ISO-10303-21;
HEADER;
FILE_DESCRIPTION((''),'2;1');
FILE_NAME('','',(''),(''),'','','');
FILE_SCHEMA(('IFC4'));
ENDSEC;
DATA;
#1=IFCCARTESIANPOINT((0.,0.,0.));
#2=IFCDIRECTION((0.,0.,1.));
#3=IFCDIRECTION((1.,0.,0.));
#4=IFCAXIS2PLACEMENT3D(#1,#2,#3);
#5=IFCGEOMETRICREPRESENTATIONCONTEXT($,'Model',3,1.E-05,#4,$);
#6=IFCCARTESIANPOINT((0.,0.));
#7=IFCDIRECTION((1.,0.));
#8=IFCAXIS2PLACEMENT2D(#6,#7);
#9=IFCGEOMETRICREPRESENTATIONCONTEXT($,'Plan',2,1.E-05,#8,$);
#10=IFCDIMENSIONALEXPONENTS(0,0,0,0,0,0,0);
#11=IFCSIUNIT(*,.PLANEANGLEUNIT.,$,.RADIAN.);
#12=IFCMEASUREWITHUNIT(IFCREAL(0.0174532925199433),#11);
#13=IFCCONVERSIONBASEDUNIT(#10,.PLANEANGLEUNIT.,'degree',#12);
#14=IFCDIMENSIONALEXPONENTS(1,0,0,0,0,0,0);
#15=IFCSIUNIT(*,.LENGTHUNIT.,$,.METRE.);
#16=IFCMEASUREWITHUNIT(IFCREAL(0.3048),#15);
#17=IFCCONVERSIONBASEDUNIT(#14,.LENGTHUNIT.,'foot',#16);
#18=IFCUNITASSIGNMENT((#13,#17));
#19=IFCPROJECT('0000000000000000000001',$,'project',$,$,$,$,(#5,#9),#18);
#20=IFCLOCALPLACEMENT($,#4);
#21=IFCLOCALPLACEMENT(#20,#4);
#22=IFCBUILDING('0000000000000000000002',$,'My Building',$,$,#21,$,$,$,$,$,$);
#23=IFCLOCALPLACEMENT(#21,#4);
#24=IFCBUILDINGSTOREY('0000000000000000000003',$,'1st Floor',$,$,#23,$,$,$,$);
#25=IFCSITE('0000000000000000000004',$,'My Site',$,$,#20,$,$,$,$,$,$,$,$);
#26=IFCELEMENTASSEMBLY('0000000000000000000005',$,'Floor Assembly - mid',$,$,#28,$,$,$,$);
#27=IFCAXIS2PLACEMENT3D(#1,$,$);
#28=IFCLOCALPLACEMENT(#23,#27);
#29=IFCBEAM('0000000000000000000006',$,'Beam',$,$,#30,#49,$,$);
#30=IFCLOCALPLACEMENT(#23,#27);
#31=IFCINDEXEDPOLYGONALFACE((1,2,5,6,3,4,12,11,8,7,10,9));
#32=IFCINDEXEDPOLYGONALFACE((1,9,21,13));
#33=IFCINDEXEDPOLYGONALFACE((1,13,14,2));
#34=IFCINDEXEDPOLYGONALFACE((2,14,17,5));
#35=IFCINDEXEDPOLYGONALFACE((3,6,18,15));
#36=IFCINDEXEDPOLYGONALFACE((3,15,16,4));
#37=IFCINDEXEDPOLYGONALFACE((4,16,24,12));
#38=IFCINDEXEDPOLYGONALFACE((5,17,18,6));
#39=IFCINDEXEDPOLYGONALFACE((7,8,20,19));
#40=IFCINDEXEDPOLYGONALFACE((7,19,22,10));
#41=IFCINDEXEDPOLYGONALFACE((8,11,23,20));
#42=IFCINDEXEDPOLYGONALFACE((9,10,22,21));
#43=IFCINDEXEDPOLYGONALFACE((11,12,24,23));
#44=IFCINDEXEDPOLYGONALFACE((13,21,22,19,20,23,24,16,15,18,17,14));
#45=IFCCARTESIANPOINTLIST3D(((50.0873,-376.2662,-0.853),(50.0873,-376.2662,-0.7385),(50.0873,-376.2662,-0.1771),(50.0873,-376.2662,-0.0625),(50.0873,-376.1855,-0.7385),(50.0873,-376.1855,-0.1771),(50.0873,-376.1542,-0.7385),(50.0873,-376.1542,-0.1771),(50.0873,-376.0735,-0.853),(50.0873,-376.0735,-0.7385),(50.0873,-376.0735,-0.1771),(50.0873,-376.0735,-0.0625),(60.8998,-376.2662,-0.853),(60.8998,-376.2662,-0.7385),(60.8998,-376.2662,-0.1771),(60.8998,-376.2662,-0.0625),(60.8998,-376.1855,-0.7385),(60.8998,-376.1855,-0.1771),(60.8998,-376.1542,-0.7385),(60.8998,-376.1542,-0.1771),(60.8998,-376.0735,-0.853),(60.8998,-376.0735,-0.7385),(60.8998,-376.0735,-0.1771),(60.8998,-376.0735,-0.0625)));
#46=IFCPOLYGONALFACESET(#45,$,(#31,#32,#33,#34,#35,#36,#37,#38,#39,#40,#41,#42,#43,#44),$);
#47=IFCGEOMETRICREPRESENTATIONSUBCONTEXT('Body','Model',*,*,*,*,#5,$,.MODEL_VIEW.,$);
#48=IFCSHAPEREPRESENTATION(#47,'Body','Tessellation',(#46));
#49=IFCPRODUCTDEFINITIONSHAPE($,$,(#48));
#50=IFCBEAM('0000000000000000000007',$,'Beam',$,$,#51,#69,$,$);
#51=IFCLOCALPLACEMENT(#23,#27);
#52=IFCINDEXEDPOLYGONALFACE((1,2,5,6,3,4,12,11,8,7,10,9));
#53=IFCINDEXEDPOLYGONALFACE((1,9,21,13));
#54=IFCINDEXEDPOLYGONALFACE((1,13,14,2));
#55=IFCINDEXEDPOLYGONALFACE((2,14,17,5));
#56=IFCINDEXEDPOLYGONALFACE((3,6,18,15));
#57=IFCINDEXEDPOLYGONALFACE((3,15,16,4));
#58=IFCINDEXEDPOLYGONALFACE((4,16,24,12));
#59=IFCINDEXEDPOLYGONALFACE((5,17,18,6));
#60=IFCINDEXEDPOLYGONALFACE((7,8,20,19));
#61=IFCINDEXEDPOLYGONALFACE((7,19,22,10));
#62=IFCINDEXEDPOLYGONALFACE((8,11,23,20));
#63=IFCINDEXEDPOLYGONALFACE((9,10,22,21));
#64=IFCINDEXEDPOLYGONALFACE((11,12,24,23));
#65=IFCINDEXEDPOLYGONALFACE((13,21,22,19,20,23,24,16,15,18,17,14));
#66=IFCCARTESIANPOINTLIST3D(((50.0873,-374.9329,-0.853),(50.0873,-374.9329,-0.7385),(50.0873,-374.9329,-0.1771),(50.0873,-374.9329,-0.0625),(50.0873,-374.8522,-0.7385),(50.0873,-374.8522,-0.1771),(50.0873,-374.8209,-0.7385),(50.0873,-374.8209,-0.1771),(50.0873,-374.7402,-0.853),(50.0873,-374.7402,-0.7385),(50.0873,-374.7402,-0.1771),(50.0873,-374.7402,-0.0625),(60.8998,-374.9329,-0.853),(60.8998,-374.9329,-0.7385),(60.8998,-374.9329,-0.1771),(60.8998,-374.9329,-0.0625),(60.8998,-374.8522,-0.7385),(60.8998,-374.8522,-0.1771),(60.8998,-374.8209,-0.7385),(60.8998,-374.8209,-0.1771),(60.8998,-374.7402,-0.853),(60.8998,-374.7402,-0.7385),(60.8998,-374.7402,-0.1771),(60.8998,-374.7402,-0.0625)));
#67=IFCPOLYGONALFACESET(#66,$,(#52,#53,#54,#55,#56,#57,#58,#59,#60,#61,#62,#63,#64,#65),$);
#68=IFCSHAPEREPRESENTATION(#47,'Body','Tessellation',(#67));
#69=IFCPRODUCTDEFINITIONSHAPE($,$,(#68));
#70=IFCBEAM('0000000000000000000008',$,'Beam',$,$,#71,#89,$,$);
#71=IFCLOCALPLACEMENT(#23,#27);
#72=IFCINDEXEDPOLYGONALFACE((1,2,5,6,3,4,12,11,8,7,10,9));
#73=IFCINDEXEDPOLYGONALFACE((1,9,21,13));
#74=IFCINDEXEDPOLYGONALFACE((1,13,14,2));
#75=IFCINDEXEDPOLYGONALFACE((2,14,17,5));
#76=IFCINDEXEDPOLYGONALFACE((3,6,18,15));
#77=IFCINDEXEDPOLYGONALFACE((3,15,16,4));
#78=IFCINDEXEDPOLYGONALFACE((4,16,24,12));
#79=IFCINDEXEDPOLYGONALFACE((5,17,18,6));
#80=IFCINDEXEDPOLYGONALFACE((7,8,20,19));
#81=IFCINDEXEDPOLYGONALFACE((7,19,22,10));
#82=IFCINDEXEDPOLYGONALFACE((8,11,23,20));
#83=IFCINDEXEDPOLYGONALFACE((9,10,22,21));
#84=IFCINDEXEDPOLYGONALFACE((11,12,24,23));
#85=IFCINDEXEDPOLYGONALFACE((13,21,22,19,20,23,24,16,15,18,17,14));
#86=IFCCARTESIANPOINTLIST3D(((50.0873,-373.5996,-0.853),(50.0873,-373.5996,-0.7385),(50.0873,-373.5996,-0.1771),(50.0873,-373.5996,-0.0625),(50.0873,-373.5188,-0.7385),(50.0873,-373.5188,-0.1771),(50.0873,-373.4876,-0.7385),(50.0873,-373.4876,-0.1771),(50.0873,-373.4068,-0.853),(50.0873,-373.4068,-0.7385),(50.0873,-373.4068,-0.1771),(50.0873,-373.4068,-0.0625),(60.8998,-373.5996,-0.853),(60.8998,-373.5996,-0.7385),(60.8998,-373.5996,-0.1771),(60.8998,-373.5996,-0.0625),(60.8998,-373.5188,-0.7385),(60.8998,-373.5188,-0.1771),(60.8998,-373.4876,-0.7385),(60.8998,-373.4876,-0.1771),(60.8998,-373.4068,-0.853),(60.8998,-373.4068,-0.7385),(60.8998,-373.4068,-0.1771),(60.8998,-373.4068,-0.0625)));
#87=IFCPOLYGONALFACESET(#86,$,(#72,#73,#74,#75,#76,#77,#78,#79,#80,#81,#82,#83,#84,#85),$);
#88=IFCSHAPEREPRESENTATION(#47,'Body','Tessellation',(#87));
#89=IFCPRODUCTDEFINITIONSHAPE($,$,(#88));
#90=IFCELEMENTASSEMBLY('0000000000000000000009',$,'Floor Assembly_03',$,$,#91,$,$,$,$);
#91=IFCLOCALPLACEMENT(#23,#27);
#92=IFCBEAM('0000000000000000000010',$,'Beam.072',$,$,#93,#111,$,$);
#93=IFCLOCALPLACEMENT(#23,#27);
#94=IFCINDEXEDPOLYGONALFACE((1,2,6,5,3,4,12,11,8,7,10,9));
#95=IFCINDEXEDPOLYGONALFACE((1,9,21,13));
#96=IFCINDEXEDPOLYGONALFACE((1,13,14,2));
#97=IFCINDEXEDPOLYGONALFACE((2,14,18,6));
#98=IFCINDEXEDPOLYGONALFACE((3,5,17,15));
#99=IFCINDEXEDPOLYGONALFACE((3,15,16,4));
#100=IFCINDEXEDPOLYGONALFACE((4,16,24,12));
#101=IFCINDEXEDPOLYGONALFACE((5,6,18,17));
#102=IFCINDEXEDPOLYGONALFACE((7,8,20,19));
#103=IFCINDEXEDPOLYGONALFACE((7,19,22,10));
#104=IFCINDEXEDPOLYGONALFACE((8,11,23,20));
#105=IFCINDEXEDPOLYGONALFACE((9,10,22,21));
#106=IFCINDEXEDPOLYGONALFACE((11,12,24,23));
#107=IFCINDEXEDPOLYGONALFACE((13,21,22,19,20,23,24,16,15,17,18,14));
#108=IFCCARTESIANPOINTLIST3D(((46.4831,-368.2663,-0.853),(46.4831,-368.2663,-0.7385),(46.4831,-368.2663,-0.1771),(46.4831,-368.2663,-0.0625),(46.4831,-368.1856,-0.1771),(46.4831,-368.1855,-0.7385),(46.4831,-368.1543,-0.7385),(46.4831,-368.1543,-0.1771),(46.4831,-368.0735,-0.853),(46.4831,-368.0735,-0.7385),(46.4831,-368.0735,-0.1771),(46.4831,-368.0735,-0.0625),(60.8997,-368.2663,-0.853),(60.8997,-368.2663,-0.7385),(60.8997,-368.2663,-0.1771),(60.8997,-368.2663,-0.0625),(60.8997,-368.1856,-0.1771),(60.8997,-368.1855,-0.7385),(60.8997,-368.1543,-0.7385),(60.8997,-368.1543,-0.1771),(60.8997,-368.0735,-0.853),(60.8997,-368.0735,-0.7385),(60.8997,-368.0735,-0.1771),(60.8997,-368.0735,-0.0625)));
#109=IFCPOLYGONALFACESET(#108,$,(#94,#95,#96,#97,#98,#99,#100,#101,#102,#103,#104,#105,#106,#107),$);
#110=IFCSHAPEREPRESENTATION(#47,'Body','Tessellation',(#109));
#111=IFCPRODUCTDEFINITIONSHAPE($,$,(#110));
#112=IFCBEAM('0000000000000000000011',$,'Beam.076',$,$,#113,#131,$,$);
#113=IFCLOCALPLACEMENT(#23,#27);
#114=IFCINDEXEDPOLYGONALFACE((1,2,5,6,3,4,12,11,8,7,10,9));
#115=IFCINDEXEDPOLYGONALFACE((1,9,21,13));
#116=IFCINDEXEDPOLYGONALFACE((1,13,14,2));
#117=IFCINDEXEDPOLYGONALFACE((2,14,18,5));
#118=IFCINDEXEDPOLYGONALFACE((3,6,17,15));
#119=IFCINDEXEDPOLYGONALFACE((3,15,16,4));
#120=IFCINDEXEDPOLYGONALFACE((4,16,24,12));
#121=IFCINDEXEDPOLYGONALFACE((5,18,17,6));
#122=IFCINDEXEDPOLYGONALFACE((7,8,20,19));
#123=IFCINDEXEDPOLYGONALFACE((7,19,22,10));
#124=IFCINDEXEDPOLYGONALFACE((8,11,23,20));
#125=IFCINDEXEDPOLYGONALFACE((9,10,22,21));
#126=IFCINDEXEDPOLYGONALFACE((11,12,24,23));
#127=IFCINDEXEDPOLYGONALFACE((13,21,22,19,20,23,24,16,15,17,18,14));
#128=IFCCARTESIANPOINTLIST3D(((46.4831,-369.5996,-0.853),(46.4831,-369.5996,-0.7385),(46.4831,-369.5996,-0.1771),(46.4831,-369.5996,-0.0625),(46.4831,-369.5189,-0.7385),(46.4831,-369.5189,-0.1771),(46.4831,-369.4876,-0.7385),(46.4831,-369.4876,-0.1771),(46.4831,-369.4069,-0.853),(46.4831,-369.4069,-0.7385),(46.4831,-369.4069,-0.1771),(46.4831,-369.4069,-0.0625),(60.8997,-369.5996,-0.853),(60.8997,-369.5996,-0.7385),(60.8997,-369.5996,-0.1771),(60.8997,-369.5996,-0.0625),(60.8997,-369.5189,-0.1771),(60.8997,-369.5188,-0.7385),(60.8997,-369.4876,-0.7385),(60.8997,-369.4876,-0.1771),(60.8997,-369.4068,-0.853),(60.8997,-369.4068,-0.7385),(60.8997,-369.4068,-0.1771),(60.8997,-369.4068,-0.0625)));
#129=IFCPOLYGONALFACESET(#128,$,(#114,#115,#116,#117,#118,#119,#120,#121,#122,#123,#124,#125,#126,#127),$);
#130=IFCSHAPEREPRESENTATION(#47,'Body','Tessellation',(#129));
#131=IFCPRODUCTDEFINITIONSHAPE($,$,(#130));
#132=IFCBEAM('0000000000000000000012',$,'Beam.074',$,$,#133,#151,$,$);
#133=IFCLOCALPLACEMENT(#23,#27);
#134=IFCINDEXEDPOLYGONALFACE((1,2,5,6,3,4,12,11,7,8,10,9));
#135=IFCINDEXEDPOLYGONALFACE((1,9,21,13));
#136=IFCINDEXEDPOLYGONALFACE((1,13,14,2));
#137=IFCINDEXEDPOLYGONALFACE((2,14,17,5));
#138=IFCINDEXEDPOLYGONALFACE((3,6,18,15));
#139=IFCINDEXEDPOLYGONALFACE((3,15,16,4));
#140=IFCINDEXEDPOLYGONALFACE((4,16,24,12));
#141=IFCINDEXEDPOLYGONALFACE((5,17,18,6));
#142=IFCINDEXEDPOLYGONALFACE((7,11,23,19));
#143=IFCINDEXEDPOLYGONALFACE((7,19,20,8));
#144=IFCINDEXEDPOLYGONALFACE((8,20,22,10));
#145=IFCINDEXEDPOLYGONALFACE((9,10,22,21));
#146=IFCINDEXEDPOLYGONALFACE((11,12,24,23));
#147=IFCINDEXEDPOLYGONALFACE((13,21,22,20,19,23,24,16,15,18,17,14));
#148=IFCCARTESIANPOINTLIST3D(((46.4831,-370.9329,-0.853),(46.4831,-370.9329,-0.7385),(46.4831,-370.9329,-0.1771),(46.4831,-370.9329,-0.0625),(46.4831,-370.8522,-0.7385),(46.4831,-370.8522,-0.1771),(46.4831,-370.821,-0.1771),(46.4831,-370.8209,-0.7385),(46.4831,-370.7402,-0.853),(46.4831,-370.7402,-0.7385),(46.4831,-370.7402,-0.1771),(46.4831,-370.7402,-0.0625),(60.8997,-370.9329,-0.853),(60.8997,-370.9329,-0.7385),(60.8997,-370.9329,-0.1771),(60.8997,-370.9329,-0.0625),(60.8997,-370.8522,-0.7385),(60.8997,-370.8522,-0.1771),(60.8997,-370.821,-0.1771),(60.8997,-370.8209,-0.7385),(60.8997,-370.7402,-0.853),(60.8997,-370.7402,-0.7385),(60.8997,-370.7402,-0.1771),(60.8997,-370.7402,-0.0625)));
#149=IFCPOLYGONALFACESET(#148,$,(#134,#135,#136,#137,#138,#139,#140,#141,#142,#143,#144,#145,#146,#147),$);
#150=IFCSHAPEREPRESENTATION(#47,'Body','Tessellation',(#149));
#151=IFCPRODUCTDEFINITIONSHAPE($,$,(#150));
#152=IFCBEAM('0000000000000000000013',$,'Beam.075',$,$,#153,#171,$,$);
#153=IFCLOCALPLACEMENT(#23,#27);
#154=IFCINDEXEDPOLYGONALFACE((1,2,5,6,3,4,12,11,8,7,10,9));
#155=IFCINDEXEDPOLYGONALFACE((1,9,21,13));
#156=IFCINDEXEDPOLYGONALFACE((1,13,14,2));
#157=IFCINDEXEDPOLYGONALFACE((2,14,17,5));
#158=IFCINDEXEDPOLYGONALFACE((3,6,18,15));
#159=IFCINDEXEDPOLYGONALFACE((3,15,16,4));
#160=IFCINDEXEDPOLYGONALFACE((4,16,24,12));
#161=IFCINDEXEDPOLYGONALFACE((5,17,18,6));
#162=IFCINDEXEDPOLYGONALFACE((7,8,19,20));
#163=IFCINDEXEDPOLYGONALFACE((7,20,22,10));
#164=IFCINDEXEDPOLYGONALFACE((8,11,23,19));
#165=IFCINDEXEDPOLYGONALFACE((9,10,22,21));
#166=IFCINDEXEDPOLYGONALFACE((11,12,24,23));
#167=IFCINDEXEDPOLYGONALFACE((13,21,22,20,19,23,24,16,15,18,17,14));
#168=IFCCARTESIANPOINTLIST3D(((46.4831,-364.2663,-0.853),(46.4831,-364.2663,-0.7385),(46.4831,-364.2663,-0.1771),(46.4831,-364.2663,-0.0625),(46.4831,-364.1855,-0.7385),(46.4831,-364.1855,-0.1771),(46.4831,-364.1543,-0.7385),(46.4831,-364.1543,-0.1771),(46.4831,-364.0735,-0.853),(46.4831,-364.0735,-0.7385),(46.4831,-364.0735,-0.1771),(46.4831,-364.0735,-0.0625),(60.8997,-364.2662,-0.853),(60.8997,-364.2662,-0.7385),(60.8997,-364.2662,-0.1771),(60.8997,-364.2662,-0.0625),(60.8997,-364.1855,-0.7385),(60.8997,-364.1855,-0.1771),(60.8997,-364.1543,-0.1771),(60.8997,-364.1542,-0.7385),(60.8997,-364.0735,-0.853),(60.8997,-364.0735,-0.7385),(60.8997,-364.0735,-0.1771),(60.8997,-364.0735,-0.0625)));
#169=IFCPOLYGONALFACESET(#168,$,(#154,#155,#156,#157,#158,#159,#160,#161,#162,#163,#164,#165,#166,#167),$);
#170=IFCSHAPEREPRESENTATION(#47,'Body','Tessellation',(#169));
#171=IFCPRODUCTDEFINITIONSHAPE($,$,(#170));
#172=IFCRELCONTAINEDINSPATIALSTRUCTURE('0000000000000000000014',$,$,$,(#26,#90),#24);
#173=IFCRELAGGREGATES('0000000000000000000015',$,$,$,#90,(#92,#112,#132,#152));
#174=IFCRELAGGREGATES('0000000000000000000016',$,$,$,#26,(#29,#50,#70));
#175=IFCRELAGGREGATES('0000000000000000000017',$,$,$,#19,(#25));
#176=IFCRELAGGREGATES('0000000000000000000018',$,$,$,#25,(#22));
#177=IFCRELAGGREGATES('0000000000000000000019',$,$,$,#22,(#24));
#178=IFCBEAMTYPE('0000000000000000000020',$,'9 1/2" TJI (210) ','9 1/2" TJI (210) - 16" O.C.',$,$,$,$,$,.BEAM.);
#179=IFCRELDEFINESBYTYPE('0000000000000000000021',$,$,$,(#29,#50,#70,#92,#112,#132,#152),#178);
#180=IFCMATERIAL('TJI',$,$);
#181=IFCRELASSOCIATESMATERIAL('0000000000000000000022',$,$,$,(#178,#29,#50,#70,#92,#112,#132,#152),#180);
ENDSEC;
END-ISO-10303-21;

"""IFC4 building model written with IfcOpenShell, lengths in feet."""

from ifc_helpers import new_model, entity, si_unit, converted_unit, frame, origin_with_axes, origin_2d_with_axis, place, context, subcontext, project, spatial, indexed_curve, outline, extrude, material, material_profile, profile_set, profile_usage, type_object, element, aggregate, save


model = new_model("IFC4")

# Units and contexts
model_context = context("Model", 3, precision=1e-05, world=origin_with_axes())
plan_context = context("Plan", 2, precision=1e-05, world=origin_2d_with_axis())
body_context = subcontext(model_context, "Body", "Model", "MODEL_VIEW")
ifc_project = project(units=[converted_unit("PLANEANGLEUNIT", "degree", entity("IfcReal", 0.0174532925199433), si_unit("PLANEANGLEUNIT", "RADIAN"), dimensions=[0, 0, 0, 0, 0, 0, 0]), converted_unit("LENGTHUNIT", "foot", entity("IfcReal", 0.3048), si_unit("LENGTHUNIT", "METRE"), dimensions=[1, 0, 0, 0, 0, 0, 0])], contexts=[model_context, plan_context])

# Site, building, storey
site_placement = place(None, origin_with_axes())
site = spatial("IfcSite", under=ifc_project, at=site_placement, Name="My Site")
building_placement = place(site_placement, origin_with_axes())
building = spatial("IfcBuilding", under=site, at=building_placement, Name="My Building")
storey_placement = place(building_placement, origin_with_axes())
storey = spatial("IfcBuildingStorey", under=building, at=storey_placement, Name="1st Floor")

# Element assemblies, beams
assembly_1_placement = place(storey_placement, frame((50.0352, -373.4068, -0.0625), z_axis=(0.0, 0.0, 1.0), x_axis=(1.0, 0.0, 0.0)))
assembly_1 = element("IfcElementAssembly", 1, at=assembly_1_placement, inside=storey, Name="Floor Assembly - mid")
ifc_material_1 = material(Name="TJI")
ifc_material_profile_1 = material_profile(ifc_material_1, outline(indexed_curve([(0.0964, 0.7905), (-0.0964, 0.7905), (-0.0964, 0.6759), (-0.0156, 0.6759), (-0.0156, 0.1146), (-0.0964, 0.1146), (-0.0964, 0.0), (0.0964, 0.0), (0.0964, 0.1146), (0.0156, 0.1146), (0.0157, 0.6759), (0.0964, 0.6759), (0.0964, 0.7905)])))
ifc_profile_set_1 = profile_set([ifc_material_profile_1])
beam_type_1 = type_object("IfcBeamType", Name="9 1/2\" TJI (210) ", Description="9 1/2\" TJI (210) - 16\" O.C.", PredefinedType="BEAM", material=ifc_profile_set_1)
ifc_profile_usage_1 = profile_usage(ifc_profile_set_1, cardinal=5)
beam_1_placement = place(assembly_1_placement, frame((0.0521, -2.763, -0.7905), z_axis=(1.0, 0.0, 0.0), x_axis=(0.0, 1.0, 0.0)))
beam_1 = element("IfcBeam", 2, at=beam_1_placement, type_object=beam_type_1, material=ifc_profile_usage_1, Name="Beam", context=body_context, shape_type="SweptSolid", body=[
    extrude(outline(indexed_curve([(0.0964, 0.7905), (-0.0964, 0.7905), (-0.0964, 0.6759), (-0.0156, 0.6759), (-0.0156, 0.1146), (-0.0964, 0.1146), (-0.0964, 0.0), (0.0964, 0.0), (0.0964, 0.1146), (0.0156, 0.1146), (0.0157, 0.6759), (0.0964, 0.6759), (0.0964, 0.7905)])), origin_with_axes(), (0.0, 0.0, 1.0), 10.8125),
])
ifc_profile_usage_2 = profile_usage(ifc_profile_set_1, cardinal=5)
beam_2_placement = place(assembly_1_placement, frame((0.0521, -1.4297, -0.7905), z_axis=(1.0, 0.0, 0.0), x_axis=(0.0, 1.0, 0.0)))
beam_2 = element("IfcBeam", 3, at=beam_2_placement, type_object=beam_type_1, material=ifc_profile_usage_2, Name="Beam", context=body_context, shape_type="SweptSolid", body=[
    extrude(outline(indexed_curve([(0.0964, 0.7905), (-0.0964, 0.7905), (-0.0964, 0.6759), (-0.0156, 0.6759), (-0.0156, 0.1146), (-0.0964, 0.1146), (-0.0964, 0.0), (0.0964, 0.0), (0.0964, 0.1146), (0.0156, 0.1146), (0.0157, 0.6759), (0.0964, 0.6759), (0.0964, 0.7905)])), origin_with_axes(), (0.0, 0.0, 1.0), 10.8125),
])
ifc_profile_usage_3 = profile_usage(ifc_profile_set_1, cardinal=5)
beam_3_placement = place(assembly_1_placement, frame((0.0521, -0.0964, -0.7905), z_axis=(1.0, 0.0, 0.0), x_axis=(0.0, 1.0, 0.0)))
beam_3 = element("IfcBeam", 4, at=beam_3_placement, type_object=beam_type_1, material=ifc_profile_usage_3, Name="Beam", context=body_context, shape_type="SweptSolid", body=[
    extrude(outline(indexed_curve([(0.0964, 0.7905), (-0.0964, 0.7905), (-0.0964, 0.6759), (-0.0156, 0.6759), (-0.0156, 0.1146), (-0.0964, 0.1146), (-0.0964, 0.0), (0.0964, 0.0), (0.0964, 0.1146), (0.0156, 0.1146), (0.0157, 0.6759), (0.0964, 0.6759), (0.0964, 0.7905)])), origin_with_axes(), (0.0, 0.0, 1.0), 10.8125),
])
assembly_2_placement = place(storey_placement, frame((60.8998, -373.5996, -0.0625), z_axis=(0.0, 0.0, 1.0), x_axis=(-1.0, -0.000001, 0.0)))
assembly_2 = element("IfcElementAssembly", 5, at=assembly_2_placement, inside=storey, Name="Floor Assembly_03")
ifc_profile_usage_4 = profile_usage(ifc_profile_set_1, cardinal=5)
beam_4_placement = place(assembly_2_placement, frame((0.0, -5.4297, -0.7905), z_axis=(1.0, 0.0, 0.0), x_axis=(0.0, 1.0, 0.0)))
beam_4 = element("IfcBeam", 6, at=beam_4_placement, type_object=beam_type_1, material=ifc_profile_usage_4, Name="Beam.072", context=body_context, shape_type="SweptSolid", body=[
    extrude(outline(indexed_curve([(0.0964, 0.7905), (-0.0964, 0.7905), (-0.0964, 0.6759), (-0.0156, 0.6759), (-0.0156, 0.1146), (-0.0964, 0.1146), (-0.0964, 0.0), (0.0964, 0.0), (0.0964, 0.1146), (0.0156, 0.1146), (0.0157, 0.6759), (0.0964, 0.6759), (0.0964, 0.7905)])), origin_with_axes(), (0.0, 0.0, 1.0), 14.4167),
])
ifc_profile_usage_5 = profile_usage(ifc_profile_set_1, cardinal=5)
beam_5_placement = place(assembly_2_placement, frame((0.0, -4.0964, -0.7905), z_axis=(1.0, 0.0, 0.0), x_axis=(0.0, 1.0, 0.0)))
beam_5 = element("IfcBeam", 7, at=beam_5_placement, type_object=beam_type_1, material=ifc_profile_usage_5, Name="Beam.076", context=body_context, shape_type="SweptSolid", body=[
    extrude(outline(indexed_curve([(0.0964, 0.7905), (-0.0964, 0.7905), (-0.0964, 0.6759), (-0.0156, 0.6759), (-0.0156, 0.1146), (-0.0964, 0.1146), (-0.0964, 0.0), (0.0964, 0.0), (0.0964, 0.1146), (0.0156, 0.1146), (0.0157, 0.6759), (0.0964, 0.6759), (0.0964, 0.7905)])), origin_with_axes(), (0.0, 0.0, 1.0), 14.4167),
])
ifc_profile_usage_6 = profile_usage(ifc_profile_set_1, cardinal=5)
beam_6_placement = place(assembly_2_placement, frame((0.0, -2.763, -0.7905), z_axis=(1.0, 0.0, 0.0), x_axis=(0.0, 1.0, 0.0)))
beam_6 = element("IfcBeam", 8, at=beam_6_placement, type_object=beam_type_1, material=ifc_profile_usage_6, Name="Beam.074", context=body_context, shape_type="SweptSolid", body=[
    extrude(outline(indexed_curve([(0.0964, 0.7905), (-0.0964, 0.7905), (-0.0964, 0.6759), (-0.0156, 0.6759), (-0.0156, 0.1146), (-0.0964, 0.1146), (-0.0964, 0.0), (0.0964, 0.0), (0.0964, 0.1146), (0.0156, 0.1146), (0.0157, 0.6759), (0.0964, 0.6759), (0.0964, 0.7905)])), origin_with_axes(), (0.0, 0.0, 1.0), 14.4167),
])
ifc_profile_usage_7 = profile_usage(ifc_profile_set_1, cardinal=5)
beam_7_placement = place(assembly_2_placement, frame((0.0, -9.4297, -0.7905), z_axis=(1.0, 0.0, 0.0), x_axis=(0.0, 1.0, 0.0)))
beam_7 = element("IfcBeam", 9, at=beam_7_placement, type_object=beam_type_1, material=ifc_profile_usage_7, Name="Beam.075", context=body_context, shape_type="SweptSolid", body=[
    extrude(outline(indexed_curve([(0.0964, 0.7905), (-0.0964, 0.7905), (-0.0964, 0.6759), (-0.0156, 0.6759), (-0.0156, 0.1146), (-0.0964, 0.1146), (-0.0964, 0.0), (0.0964, 0.0), (0.0964, 0.1146), (0.0156, 0.1146), (0.0157, 0.6759), (0.0964, 0.6759), (0.0964, 0.7905)])), origin_with_axes(), (0.0, 0.0, 1.0), 14.4167),
])
aggregate(assembly_2, [beam_4, beam_5, beam_6, beam_7])

aggregate(assembly_1, [beam_1, beam_2, beam_3])

save(model, "model.ifc")
